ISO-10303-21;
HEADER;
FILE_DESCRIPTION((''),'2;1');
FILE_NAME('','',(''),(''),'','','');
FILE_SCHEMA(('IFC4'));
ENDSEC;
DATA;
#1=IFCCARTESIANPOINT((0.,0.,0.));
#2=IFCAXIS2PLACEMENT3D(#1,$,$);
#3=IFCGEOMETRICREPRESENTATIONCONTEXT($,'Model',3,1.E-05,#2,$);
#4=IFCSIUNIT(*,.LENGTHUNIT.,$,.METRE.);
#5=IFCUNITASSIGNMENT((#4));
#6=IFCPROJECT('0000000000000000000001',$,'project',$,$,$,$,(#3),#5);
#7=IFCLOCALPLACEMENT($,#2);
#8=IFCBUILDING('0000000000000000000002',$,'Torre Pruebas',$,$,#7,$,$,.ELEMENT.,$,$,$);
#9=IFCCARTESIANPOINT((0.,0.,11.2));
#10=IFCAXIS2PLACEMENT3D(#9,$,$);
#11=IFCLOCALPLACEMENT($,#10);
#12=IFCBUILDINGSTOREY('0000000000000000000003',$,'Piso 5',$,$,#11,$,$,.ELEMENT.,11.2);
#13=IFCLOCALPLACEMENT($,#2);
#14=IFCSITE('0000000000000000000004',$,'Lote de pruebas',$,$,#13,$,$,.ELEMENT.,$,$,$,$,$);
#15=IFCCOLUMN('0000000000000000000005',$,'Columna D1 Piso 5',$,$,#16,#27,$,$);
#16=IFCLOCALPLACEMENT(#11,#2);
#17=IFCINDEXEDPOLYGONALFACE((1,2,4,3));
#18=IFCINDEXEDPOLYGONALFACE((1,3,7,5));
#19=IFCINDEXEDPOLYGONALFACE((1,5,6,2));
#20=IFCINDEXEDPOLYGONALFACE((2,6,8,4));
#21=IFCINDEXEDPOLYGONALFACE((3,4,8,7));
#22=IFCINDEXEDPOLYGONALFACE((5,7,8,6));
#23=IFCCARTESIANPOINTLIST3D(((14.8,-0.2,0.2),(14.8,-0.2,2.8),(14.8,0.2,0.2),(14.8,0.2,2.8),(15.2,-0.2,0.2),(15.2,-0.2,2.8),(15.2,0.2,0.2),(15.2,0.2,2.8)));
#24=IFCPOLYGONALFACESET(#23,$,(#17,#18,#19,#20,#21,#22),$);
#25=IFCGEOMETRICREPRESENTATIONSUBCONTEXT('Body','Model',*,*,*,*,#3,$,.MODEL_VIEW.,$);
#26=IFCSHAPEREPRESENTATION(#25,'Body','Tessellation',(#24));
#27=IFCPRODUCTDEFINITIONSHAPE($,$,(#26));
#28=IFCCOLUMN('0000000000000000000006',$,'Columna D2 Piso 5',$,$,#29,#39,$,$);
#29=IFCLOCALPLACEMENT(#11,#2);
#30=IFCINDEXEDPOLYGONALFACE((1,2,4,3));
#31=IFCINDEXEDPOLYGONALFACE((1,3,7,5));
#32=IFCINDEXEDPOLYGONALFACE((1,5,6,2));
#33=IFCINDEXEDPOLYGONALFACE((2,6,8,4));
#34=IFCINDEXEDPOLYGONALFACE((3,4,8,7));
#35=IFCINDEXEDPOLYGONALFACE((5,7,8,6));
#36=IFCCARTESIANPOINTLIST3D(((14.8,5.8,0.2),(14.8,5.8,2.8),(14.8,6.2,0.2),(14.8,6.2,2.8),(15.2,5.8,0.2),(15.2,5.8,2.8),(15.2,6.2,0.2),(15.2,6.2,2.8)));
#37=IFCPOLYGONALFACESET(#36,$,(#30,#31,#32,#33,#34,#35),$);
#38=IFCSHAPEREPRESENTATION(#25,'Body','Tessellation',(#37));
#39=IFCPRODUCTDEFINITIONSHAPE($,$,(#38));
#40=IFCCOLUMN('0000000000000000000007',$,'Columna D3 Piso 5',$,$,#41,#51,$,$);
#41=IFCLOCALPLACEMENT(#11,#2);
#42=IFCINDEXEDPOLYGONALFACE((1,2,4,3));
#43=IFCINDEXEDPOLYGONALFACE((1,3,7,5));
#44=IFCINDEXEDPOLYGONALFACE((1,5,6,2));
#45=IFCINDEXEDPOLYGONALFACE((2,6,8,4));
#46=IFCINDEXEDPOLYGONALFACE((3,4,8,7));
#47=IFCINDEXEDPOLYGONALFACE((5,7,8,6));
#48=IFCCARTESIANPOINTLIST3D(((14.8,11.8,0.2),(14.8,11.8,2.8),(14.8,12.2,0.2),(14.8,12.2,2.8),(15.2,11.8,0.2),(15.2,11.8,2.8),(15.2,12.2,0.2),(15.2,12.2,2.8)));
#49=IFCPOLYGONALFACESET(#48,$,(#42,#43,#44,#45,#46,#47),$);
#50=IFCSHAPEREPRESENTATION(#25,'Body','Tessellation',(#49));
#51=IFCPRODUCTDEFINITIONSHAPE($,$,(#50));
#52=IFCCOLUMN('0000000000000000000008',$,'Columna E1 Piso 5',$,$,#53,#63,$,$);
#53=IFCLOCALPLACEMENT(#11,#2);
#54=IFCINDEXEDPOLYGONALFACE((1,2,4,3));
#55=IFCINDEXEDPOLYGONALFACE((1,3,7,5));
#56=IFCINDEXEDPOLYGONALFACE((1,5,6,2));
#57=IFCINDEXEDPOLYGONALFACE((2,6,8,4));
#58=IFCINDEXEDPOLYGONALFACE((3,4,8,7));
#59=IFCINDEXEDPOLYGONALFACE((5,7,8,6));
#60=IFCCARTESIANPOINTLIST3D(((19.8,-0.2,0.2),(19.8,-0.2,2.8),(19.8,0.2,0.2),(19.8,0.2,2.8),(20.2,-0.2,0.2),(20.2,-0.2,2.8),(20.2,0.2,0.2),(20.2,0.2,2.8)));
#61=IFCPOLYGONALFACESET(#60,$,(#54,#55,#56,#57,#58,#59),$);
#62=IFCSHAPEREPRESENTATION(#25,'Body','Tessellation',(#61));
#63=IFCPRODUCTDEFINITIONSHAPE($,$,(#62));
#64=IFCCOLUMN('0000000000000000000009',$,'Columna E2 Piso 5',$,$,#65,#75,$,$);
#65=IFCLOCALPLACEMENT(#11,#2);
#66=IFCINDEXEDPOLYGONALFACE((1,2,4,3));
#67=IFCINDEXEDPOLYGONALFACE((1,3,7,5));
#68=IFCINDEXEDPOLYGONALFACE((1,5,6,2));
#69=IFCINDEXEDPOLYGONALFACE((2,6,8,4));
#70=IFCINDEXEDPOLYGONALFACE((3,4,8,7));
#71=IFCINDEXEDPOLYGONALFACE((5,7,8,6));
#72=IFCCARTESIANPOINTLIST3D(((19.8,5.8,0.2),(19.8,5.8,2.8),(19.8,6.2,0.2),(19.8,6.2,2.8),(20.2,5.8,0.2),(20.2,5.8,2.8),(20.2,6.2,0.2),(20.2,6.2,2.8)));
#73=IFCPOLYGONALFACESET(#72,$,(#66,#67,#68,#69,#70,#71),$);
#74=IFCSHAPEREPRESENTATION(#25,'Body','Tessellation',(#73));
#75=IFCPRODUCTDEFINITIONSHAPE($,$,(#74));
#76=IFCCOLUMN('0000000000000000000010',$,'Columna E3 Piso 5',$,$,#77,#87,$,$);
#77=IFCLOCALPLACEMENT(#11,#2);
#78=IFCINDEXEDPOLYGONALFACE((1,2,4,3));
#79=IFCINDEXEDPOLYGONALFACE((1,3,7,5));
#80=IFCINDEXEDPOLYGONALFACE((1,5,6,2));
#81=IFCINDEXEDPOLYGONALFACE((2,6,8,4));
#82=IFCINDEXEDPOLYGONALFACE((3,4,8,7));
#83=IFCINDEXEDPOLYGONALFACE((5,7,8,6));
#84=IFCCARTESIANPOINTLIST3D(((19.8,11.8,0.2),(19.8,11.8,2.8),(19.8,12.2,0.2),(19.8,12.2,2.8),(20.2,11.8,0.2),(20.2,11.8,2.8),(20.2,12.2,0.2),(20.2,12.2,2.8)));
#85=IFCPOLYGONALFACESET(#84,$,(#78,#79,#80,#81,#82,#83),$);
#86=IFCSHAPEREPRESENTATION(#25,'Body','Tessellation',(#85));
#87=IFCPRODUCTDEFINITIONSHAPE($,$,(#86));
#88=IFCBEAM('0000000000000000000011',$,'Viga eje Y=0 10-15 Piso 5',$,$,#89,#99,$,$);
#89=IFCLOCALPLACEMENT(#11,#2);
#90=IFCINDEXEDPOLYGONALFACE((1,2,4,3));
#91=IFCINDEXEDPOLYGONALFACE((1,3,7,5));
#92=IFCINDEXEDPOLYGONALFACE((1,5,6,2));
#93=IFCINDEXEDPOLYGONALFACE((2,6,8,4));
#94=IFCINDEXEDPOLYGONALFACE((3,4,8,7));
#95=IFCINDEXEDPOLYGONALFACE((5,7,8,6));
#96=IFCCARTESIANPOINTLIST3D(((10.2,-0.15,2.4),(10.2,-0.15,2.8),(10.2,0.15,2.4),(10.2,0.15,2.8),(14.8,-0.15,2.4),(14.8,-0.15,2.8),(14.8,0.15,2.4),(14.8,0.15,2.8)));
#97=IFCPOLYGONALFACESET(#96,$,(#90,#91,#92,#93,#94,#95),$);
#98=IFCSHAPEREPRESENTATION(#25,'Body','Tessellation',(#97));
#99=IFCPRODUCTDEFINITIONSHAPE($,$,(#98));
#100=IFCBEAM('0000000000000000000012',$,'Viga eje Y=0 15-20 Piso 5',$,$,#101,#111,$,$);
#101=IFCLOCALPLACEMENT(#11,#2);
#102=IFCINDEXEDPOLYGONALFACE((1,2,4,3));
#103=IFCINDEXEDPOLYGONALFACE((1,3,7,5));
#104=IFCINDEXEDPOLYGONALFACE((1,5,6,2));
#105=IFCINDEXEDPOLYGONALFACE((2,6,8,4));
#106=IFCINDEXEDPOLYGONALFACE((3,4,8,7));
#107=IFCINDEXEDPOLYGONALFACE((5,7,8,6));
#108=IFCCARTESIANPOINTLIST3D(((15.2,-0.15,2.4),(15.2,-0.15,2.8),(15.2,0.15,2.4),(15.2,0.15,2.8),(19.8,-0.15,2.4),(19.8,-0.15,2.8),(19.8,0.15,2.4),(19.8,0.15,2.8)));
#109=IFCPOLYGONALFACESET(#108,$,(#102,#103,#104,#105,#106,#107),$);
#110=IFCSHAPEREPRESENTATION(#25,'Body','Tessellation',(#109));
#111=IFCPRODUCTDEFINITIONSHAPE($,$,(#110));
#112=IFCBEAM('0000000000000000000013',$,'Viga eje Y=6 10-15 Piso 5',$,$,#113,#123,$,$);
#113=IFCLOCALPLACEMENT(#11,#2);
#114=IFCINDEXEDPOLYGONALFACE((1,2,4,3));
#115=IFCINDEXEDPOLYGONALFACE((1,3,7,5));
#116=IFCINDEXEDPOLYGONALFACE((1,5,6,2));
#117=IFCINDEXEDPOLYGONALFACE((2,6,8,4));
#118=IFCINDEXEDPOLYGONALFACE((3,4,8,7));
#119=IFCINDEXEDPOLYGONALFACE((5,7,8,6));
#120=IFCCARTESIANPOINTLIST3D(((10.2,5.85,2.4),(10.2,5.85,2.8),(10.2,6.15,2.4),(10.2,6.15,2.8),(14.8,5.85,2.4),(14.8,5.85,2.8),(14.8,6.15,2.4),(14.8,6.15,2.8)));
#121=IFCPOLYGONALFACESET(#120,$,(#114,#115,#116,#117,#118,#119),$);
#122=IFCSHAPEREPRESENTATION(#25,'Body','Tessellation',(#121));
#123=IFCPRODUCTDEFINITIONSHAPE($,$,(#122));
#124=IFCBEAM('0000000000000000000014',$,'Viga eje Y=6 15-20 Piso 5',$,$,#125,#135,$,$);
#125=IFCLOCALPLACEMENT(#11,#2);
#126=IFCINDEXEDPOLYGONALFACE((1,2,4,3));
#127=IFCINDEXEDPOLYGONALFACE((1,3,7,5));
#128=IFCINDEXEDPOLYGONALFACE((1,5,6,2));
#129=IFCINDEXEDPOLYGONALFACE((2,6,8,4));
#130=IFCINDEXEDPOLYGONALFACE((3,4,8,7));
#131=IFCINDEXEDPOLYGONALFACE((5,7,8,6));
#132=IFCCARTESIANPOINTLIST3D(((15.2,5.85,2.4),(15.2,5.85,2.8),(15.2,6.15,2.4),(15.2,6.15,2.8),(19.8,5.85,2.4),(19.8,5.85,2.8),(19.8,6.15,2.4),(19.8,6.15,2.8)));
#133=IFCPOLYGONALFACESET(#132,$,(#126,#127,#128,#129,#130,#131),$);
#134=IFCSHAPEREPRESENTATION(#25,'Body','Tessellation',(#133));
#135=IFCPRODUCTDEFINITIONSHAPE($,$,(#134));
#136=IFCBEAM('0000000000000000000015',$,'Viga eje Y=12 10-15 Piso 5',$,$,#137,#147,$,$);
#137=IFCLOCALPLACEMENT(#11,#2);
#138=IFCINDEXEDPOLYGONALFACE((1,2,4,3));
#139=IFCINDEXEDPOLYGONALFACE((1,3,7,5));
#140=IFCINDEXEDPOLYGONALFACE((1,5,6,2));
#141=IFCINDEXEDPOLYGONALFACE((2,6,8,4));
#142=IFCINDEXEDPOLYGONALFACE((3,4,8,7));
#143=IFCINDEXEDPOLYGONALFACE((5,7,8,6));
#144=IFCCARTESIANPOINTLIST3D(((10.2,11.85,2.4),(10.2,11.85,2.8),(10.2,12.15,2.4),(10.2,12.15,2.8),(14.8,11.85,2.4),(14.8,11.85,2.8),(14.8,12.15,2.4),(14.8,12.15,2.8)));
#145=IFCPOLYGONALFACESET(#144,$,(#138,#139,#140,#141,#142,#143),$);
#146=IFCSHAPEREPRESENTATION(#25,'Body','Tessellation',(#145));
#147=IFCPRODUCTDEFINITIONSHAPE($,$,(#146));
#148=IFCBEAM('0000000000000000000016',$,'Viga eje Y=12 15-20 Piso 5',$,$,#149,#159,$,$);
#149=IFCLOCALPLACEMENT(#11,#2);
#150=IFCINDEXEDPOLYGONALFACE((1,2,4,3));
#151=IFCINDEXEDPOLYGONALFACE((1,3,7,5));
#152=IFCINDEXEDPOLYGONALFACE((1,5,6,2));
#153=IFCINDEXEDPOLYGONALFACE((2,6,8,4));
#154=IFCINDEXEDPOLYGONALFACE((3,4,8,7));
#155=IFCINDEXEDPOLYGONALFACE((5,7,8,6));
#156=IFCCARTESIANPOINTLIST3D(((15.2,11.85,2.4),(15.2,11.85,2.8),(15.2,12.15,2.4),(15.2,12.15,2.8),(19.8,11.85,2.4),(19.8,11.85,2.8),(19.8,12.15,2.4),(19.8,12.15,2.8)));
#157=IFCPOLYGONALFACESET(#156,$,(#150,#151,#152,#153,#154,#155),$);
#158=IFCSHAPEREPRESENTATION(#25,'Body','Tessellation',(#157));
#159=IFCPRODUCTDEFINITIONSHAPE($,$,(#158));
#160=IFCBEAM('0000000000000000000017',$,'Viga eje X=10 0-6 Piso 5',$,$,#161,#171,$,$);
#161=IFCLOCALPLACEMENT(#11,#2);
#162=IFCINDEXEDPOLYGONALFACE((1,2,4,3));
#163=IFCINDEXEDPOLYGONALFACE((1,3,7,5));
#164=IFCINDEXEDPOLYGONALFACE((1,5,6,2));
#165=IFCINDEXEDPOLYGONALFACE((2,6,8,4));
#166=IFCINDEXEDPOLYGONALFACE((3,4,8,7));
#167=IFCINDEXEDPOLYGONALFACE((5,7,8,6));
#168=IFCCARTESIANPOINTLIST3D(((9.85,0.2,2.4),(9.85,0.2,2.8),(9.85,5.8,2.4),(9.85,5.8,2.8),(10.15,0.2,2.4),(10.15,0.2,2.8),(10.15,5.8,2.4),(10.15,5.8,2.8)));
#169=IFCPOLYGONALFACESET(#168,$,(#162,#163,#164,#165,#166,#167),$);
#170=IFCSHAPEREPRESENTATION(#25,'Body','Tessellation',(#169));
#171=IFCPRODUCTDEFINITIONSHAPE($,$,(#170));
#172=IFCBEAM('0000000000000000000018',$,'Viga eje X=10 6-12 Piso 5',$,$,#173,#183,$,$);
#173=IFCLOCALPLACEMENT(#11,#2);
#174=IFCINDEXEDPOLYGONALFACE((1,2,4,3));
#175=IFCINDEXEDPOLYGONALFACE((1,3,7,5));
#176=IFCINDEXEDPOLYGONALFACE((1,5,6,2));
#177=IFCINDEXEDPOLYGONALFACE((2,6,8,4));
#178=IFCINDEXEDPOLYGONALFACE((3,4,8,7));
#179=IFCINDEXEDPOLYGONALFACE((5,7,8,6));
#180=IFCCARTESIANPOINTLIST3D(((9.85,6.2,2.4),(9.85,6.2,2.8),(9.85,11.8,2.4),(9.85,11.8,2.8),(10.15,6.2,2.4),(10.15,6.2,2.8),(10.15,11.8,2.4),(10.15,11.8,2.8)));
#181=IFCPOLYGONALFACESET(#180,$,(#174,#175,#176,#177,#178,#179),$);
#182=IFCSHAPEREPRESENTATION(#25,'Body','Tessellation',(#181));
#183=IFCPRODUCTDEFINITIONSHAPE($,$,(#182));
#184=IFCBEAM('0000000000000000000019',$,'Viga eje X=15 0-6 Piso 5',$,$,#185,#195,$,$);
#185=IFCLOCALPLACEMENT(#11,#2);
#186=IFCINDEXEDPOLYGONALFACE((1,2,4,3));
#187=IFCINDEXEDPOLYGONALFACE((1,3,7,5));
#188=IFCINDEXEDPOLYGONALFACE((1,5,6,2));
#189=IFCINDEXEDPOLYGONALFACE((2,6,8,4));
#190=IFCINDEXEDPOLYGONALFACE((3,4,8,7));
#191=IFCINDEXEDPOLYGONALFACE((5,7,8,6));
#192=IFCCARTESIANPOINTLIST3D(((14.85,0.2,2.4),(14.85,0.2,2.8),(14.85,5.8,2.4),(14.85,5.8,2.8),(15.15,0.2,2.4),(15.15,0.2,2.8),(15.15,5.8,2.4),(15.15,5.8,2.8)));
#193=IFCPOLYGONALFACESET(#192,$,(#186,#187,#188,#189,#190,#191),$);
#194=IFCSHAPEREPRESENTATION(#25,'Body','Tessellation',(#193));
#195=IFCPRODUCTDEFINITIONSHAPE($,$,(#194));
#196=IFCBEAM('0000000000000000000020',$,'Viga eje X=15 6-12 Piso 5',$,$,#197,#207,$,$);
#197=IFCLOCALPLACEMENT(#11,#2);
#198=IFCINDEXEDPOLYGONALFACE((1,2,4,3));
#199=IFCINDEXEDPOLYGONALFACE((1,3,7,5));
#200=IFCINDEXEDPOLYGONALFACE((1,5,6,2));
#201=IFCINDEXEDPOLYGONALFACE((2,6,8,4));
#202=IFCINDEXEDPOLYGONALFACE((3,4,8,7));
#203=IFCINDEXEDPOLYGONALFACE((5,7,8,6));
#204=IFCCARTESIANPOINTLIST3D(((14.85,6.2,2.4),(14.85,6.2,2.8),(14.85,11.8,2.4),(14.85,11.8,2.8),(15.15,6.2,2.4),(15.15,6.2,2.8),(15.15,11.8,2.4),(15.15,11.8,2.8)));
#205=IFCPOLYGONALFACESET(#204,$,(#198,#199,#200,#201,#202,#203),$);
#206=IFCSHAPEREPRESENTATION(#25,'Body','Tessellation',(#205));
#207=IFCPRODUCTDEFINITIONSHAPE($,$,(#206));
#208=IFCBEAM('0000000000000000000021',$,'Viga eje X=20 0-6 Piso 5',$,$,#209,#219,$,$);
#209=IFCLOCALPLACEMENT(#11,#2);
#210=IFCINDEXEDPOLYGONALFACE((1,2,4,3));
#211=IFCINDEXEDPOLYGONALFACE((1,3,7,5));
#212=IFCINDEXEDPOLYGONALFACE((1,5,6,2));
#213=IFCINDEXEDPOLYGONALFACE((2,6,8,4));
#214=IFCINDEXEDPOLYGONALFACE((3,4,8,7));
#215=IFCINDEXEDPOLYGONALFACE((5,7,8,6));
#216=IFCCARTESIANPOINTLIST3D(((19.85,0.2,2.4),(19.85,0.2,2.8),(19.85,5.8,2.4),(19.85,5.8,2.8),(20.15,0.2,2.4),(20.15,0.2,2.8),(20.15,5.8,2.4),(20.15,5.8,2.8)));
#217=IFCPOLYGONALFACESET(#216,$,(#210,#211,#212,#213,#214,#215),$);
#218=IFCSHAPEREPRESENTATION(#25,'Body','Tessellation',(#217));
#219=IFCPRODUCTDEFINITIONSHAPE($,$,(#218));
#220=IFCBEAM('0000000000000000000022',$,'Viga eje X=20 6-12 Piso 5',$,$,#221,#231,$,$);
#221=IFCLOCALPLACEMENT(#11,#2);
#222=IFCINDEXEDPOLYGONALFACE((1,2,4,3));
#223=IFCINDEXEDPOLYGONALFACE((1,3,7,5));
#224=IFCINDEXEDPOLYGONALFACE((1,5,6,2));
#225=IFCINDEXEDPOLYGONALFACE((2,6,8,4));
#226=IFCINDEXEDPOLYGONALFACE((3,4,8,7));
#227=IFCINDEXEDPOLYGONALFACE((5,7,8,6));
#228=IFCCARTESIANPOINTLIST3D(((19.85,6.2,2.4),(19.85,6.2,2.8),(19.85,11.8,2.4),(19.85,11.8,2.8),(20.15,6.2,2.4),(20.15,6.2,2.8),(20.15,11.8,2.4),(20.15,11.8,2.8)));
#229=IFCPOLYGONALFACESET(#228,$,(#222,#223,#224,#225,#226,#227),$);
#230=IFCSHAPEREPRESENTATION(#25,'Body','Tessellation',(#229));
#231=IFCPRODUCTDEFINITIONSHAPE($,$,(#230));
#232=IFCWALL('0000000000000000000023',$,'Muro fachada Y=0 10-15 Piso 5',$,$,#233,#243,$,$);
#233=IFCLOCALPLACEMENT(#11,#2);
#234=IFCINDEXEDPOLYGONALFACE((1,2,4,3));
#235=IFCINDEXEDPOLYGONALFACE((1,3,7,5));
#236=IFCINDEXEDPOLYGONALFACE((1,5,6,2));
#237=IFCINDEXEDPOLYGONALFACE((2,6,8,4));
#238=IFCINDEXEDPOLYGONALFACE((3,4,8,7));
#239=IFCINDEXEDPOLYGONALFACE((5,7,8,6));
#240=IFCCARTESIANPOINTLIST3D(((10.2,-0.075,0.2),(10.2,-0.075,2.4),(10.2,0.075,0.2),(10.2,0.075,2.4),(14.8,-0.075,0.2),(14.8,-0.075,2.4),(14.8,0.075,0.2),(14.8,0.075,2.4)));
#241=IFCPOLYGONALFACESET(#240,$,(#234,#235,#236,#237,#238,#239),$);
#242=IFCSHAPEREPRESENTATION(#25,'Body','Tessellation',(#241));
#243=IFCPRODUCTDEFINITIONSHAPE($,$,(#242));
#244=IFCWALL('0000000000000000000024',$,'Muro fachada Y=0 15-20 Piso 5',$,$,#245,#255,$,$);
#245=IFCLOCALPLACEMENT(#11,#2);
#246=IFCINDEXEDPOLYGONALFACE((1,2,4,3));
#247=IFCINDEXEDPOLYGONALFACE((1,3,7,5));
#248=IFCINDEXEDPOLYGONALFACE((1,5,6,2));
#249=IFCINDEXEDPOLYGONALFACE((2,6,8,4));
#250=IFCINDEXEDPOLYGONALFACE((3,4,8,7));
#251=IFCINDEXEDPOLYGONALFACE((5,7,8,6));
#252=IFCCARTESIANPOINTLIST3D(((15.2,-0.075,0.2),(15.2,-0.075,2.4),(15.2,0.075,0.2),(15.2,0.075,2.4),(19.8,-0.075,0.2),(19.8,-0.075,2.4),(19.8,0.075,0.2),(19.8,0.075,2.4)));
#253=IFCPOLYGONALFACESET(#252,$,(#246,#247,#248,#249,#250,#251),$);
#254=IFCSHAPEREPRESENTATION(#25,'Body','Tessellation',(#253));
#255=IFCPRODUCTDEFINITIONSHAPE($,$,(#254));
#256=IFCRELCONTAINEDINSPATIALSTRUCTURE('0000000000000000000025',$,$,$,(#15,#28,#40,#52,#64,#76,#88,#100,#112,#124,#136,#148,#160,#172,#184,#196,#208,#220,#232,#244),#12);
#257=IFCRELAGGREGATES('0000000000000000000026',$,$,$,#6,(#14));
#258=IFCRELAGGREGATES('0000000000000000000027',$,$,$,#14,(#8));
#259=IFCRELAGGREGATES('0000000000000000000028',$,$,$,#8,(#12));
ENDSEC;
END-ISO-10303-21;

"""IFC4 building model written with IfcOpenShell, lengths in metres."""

from ifc_helpers import new_model, si_unit, frame, origin, origin_2d, place, context, subcontext, project, spatial, rectangle, extrude, element, save


model = new_model("IFC4")

# Units and contexts
model_context = context("Model", 3, precision=1e-05, world=origin())
body_context = subcontext(model_context, "Body", "Model", "MODEL_VIEW")
ifc_project = project(units=[si_unit("LENGTHUNIT", "METRE")], contexts=[model_context])

# Site, building, storey
site_placement = place(None, origin())
site = spatial("IfcSite", under=ifc_project, at=site_placement, Name="Lote de pruebas", CompositionType="ELEMENT")
building_placement = place(None, origin())
building = spatial("IfcBuilding", under=site, at=building_placement, Name="Torre Pruebas", CompositionType="ELEMENT")
storey_placement = place(None, frame((0.0, 0.0, 11.2)))
storey = spatial("IfcBuildingStorey", under=building, at=storey_placement, Name="Piso 5", CompositionType="ELEMENT", Elevation=11.2)

# Columns
for number, where, name in (
    (1, (15.0, 0.0, 11.4), "Columna D1 Piso 5"),
    (2, (15.0, 6.0, 11.4), "Columna D2 Piso 5"),
    (3, (15.0, 12.0, 11.4), "Columna D3 Piso 5"),
    (4, (20.0, 0.0, 11.4), "Columna E1 Piso 5"),
    (5, (20.0, 6.0, 11.4), "Columna E2 Piso 5"),
    (6, (20.0, 12.0, 11.4), "Columna E3 Piso 5"),
):
    element("IfcColumn", number, at=place(None, frame(where)), inside=storey, Name=name, context=body_context, shape_type="SweptSolid", body=[
        extrude(rectangle(XDim=0.4, YDim=0.4, at=origin_2d()), origin(), (0.0, 0.0, 1.0), 2.6),
    ])

# Beams
for number, where, name in (
    (7, (12.5, 0.0, 13.6), "Viga eje Y=0 10-15 Piso 5"),
    (8, (17.5, 0.0, 13.6), "Viga eje Y=0 15-20 Piso 5"),
    (9, (12.5, 6.0, 13.6), "Viga eje Y=6 10-15 Piso 5"),
    (10, (17.5, 6.0, 13.6), "Viga eje Y=6 15-20 Piso 5"),
    (11, (12.5, 12.0, 13.6), "Viga eje Y=12 10-15 Piso 5"),
    (12, (17.5, 12.0, 13.6), "Viga eje Y=12 15-20 Piso 5"),
):
    element("IfcBeam", number, at=place(None, frame(where)), inside=storey, Name=name, context=body_context, shape_type="SweptSolid", body=[
        extrude(rectangle(XDim=4.6, YDim=0.3, at=origin_2d()), origin(), (0.0, 0.0, 1.0), 0.4),
    ])
for number, where, name in (
    (13, (10.0, 3.0, 13.6), "Viga eje X=10 0-6 Piso 5"),
    (14, (10.0, 9.0, 13.6), "Viga eje X=10 6-12 Piso 5"),
    (15, (15.0, 3.0, 13.6), "Viga eje X=15 0-6 Piso 5"),
    (16, (15.0, 9.0, 13.6), "Viga eje X=15 6-12 Piso 5"),
    (17, (20.0, 3.0, 13.6), "Viga eje X=20 0-6 Piso 5"),
    (18, (20.0, 9.0, 13.6), "Viga eje X=20 6-12 Piso 5"),
):
    element("IfcBeam", number, at=place(None, frame(where)), inside=storey, Name=name, context=body_context, shape_type="SweptSolid", body=[
        extrude(rectangle(XDim=0.3, YDim=5.6, at=origin_2d()), origin(), (0.0, 0.0, 1.0), 0.4),
    ])

# Walls
for number, where, name in (
    (19, (12.5, 0.0, 11.4), "Muro fachada Y=0 10-15 Piso 5"),
    (20, (17.5, 0.0, 11.4), "Muro fachada Y=0 15-20 Piso 5"),
):
    element("IfcWall", number, at=place(None, frame(where)), inside=storey, Name=name, context=body_context, shape_type="SweptSolid", body=[
        extrude(rectangle(XDim=4.6, YDim=0.15, at=origin_2d()), origin(), (0.0, 0.0, 1.0), 2.2),
    ])

save(model, "model.ifc")
